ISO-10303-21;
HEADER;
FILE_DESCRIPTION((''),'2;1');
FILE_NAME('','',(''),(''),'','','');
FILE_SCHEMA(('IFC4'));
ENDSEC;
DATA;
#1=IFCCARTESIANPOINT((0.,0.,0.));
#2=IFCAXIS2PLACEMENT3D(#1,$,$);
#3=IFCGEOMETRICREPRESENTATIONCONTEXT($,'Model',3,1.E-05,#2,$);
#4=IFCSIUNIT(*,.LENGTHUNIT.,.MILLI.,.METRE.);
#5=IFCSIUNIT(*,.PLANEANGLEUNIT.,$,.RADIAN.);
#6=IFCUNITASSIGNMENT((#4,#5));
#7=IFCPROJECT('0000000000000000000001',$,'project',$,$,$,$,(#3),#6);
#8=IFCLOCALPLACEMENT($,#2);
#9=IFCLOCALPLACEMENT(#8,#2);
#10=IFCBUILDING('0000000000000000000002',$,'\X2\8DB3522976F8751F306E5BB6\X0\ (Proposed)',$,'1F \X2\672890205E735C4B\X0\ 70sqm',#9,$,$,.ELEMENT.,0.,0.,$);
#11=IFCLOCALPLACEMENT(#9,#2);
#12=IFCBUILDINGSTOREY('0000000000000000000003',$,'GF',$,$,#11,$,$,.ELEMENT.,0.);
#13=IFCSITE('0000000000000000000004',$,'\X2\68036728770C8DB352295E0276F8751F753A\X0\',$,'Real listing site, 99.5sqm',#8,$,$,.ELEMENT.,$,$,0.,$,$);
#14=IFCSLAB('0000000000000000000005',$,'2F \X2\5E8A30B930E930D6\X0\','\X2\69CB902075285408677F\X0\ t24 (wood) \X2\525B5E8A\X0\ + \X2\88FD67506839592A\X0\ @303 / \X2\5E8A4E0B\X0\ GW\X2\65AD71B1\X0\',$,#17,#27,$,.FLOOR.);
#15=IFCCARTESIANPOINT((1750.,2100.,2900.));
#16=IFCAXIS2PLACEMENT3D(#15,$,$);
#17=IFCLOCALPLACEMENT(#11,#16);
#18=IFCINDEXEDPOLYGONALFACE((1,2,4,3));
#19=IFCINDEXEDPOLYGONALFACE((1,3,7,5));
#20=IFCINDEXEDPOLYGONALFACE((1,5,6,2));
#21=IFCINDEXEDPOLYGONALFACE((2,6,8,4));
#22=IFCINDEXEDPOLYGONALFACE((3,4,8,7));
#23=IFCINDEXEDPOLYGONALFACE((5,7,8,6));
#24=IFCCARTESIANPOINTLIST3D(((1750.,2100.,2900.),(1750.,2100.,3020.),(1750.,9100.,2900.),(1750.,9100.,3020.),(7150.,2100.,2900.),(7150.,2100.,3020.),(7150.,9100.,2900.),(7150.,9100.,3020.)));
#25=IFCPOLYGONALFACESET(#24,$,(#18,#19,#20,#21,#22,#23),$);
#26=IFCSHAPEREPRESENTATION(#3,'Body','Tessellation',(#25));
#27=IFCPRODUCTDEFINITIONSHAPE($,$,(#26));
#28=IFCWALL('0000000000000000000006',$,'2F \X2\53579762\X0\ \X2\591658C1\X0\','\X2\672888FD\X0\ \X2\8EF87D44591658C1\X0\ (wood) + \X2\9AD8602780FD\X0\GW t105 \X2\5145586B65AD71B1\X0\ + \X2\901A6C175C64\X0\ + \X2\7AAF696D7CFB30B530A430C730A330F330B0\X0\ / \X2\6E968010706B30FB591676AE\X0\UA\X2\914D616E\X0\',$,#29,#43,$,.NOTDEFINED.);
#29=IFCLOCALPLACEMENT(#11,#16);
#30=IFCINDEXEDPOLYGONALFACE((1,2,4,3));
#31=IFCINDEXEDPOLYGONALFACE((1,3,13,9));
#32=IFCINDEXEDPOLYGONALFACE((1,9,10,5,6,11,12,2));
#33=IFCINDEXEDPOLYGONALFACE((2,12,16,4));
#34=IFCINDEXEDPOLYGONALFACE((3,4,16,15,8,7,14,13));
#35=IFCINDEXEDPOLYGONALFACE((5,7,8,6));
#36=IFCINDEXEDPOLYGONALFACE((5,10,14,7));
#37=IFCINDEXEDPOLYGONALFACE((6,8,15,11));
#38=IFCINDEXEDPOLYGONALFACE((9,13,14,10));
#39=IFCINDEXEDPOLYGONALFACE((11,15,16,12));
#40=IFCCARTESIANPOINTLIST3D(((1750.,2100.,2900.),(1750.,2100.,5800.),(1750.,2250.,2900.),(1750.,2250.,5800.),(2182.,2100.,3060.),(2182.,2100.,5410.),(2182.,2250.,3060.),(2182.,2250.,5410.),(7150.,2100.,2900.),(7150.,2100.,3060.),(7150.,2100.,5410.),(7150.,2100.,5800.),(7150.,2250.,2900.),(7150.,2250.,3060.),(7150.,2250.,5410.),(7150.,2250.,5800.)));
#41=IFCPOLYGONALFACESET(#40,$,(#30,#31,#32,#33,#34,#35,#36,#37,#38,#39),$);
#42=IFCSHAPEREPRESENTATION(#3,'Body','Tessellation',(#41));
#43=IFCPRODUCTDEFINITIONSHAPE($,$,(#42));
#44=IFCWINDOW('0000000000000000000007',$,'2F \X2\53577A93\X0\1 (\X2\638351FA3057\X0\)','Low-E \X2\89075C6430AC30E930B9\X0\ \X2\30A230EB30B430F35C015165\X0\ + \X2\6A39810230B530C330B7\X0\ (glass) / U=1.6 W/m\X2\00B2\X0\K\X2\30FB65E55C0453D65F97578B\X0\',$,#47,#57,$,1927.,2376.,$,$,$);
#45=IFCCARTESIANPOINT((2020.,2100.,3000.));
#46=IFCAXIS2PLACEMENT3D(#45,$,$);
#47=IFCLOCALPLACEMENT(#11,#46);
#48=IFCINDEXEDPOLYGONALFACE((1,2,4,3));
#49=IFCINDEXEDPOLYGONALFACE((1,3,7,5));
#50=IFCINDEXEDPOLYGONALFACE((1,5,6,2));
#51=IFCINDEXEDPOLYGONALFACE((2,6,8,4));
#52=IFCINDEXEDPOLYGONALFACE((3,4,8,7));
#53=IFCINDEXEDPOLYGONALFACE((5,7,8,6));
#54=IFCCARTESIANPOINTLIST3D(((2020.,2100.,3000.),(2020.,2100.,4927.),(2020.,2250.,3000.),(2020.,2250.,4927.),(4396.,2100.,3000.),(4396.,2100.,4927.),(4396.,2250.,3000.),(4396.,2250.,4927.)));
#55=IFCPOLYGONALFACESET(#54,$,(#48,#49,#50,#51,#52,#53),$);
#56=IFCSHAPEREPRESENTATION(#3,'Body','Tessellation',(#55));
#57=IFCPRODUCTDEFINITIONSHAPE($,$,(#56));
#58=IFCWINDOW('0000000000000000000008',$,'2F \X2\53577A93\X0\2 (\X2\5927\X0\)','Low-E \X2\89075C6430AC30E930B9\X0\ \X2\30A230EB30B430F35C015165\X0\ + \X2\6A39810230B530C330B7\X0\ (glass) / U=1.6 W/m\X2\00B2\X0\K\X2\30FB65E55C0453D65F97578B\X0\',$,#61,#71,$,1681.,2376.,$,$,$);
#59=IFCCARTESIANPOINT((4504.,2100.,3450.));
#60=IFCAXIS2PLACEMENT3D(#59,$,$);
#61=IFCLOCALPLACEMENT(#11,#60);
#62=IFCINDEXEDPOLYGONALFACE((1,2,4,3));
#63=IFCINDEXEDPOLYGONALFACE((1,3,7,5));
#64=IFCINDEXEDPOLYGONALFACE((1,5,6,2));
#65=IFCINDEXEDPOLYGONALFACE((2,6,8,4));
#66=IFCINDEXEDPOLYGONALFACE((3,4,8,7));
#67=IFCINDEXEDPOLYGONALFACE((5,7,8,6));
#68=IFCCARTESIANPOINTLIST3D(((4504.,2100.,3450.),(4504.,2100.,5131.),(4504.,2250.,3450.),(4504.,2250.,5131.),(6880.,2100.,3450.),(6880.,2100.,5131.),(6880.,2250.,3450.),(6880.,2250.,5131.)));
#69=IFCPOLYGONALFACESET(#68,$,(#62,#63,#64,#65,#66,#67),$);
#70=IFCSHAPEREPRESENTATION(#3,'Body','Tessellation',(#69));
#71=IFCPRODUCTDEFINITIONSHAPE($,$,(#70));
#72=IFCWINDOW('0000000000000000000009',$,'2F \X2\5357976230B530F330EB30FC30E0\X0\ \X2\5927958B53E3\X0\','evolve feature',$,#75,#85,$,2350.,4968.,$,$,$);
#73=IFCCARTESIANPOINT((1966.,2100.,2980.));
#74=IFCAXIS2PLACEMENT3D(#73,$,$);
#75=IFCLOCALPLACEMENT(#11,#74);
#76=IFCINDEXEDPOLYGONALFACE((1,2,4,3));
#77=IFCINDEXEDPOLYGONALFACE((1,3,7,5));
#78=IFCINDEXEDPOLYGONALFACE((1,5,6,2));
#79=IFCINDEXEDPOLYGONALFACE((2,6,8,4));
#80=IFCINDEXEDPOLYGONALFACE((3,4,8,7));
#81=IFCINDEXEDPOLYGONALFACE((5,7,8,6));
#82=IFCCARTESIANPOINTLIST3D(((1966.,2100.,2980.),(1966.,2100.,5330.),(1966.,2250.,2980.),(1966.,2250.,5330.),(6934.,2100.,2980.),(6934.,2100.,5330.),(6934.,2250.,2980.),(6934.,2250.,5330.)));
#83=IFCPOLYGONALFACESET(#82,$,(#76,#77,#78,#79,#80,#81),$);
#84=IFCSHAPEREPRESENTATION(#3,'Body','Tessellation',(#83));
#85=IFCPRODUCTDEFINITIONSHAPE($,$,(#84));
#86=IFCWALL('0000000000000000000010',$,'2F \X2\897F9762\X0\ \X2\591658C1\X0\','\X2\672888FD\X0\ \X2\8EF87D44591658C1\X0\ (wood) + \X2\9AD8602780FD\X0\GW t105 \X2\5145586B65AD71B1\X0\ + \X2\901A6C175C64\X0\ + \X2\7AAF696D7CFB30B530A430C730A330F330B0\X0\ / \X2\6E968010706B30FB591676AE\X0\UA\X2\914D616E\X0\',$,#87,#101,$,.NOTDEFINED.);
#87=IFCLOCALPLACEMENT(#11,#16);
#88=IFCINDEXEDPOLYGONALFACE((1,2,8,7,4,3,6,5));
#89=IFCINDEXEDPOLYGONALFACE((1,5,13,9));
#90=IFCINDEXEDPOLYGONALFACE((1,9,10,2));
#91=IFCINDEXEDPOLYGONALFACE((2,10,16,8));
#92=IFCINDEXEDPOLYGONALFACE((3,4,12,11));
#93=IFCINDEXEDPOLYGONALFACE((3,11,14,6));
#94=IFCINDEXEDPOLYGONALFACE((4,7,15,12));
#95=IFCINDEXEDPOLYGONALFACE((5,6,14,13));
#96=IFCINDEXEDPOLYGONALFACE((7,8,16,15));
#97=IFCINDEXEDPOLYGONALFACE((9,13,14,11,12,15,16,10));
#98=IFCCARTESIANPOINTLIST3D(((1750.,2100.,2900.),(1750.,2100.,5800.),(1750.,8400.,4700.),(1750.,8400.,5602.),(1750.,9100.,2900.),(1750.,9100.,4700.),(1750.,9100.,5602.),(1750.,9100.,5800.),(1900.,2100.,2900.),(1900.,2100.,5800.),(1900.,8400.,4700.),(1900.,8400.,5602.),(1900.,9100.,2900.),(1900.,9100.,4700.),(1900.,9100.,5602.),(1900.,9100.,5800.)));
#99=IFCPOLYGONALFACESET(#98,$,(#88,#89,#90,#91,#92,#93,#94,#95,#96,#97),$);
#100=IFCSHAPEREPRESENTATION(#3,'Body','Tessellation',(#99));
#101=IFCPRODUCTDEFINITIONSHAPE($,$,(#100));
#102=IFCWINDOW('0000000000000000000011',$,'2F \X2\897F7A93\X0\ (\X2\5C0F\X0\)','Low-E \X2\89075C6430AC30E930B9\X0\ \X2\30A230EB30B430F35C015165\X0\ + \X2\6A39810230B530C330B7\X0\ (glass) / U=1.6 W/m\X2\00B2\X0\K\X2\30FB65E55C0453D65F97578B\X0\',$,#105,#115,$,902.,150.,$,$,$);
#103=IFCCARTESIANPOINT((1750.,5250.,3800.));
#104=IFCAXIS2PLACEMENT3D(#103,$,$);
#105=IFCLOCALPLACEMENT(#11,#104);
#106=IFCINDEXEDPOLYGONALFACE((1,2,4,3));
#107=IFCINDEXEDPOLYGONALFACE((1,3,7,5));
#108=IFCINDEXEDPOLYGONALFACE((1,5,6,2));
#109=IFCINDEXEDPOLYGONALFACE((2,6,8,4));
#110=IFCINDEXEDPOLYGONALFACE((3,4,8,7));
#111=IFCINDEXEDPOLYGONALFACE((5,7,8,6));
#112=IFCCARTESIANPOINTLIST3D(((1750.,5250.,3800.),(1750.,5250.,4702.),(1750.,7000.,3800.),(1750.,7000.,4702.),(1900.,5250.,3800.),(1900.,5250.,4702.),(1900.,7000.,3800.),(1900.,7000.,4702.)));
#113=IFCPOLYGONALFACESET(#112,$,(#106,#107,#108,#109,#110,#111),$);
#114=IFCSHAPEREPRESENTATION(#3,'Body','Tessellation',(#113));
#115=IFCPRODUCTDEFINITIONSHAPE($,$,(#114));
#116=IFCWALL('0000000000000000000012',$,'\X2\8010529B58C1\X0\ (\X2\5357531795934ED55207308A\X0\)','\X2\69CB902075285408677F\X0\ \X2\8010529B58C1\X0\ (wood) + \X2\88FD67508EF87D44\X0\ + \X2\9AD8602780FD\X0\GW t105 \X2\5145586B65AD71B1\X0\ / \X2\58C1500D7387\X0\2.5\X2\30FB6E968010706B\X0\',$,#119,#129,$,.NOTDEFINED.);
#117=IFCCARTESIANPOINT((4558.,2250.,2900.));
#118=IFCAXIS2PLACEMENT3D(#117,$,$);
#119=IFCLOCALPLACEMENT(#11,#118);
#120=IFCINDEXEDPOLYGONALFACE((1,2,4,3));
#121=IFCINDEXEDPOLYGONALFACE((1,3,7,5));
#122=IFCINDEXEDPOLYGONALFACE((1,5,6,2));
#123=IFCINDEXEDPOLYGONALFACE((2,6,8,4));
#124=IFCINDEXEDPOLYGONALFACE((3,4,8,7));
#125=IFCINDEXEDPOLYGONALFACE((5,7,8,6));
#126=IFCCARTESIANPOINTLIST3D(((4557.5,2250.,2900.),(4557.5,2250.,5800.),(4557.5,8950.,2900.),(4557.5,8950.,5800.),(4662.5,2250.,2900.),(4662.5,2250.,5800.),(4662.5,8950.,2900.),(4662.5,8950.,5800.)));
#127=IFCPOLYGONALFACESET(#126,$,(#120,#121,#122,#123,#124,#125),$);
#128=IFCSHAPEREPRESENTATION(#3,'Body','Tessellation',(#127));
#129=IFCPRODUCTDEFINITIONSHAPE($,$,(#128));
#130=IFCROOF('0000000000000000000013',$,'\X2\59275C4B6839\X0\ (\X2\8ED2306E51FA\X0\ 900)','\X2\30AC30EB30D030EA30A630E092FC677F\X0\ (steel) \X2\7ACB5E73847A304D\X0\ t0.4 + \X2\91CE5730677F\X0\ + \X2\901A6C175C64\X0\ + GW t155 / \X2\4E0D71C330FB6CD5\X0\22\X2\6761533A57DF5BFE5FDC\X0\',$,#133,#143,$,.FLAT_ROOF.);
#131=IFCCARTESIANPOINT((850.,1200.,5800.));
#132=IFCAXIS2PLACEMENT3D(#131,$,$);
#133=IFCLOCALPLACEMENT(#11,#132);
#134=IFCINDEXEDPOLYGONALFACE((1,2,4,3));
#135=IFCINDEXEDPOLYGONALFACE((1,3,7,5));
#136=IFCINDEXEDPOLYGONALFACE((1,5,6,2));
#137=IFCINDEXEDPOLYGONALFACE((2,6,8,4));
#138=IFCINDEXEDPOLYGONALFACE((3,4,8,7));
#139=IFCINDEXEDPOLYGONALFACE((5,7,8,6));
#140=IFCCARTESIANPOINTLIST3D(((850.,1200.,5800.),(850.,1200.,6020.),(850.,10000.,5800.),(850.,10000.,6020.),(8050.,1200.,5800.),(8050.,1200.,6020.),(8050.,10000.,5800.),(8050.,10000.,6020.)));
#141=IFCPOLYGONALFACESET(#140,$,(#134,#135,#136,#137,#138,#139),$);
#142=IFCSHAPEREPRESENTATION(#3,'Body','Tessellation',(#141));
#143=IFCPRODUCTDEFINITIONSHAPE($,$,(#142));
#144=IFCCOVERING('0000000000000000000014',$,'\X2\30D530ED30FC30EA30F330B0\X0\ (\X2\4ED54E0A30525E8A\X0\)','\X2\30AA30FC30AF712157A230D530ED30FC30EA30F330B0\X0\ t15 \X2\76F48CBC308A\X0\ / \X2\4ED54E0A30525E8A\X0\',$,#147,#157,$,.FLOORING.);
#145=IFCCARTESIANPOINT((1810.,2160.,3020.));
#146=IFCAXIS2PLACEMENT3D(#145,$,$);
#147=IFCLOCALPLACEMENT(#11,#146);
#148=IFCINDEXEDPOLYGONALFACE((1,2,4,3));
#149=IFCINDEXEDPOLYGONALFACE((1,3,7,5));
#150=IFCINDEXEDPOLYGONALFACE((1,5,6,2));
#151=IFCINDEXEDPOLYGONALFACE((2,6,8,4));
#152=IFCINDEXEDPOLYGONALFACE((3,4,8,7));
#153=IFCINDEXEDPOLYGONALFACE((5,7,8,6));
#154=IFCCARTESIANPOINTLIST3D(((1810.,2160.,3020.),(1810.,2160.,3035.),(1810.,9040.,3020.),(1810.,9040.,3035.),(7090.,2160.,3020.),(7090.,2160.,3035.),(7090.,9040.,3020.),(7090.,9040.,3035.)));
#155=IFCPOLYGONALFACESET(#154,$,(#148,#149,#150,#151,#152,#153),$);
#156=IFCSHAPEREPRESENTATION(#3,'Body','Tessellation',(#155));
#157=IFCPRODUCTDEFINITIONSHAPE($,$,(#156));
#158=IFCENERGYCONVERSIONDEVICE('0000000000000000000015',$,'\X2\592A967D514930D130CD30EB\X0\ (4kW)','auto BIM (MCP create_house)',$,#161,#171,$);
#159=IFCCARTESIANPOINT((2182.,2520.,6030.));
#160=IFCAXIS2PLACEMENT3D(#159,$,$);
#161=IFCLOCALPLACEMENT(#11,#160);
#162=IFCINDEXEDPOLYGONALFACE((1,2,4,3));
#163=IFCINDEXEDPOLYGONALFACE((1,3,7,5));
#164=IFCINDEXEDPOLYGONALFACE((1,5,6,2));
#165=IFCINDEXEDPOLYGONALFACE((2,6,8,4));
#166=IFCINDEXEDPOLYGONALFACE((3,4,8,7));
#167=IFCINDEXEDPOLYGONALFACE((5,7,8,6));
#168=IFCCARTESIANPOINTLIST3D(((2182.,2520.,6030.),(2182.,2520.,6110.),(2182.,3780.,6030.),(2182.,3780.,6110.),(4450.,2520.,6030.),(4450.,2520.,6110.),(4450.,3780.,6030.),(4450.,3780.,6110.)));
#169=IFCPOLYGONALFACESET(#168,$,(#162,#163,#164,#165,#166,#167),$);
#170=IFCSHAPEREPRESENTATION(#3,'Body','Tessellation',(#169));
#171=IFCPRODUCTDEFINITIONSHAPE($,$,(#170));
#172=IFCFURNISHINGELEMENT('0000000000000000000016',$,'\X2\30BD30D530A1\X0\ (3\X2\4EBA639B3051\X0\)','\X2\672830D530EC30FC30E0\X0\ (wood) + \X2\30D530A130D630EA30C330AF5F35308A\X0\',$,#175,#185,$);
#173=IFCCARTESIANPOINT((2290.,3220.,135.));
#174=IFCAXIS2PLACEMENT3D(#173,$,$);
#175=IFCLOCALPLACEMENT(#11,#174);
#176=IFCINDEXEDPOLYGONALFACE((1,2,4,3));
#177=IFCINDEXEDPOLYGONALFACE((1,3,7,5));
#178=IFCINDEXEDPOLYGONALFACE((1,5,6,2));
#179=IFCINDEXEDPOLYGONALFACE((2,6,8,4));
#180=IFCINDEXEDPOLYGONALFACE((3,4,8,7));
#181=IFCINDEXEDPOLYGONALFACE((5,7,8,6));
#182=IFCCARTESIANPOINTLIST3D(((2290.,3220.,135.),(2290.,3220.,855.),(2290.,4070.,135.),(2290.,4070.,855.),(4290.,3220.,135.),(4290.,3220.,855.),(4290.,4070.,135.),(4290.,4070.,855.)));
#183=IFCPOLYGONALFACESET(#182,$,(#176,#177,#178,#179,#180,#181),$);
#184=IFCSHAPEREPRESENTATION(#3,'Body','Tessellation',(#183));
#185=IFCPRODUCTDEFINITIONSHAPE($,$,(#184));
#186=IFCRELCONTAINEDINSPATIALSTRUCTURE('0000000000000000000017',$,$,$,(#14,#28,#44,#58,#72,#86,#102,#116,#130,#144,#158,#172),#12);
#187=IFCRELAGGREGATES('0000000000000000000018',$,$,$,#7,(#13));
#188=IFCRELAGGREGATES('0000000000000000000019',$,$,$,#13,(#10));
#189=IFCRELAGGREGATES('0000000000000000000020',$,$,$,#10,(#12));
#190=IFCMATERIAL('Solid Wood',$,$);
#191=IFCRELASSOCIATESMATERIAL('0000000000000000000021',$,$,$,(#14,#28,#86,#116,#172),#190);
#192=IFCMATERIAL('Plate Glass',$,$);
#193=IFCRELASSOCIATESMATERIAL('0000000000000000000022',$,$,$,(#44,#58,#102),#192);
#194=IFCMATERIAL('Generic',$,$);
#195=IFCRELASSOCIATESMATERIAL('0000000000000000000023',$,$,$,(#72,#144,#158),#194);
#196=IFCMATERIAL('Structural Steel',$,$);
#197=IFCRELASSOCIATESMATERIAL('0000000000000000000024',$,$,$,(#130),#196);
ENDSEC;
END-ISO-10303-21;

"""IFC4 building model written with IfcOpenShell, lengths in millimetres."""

from ifc_helpers import new_model, si_unit, frame, frame_2d, origin, place, context, project, spatial, rectangle, extrude, material, element, fill, save


model = new_model("IFC4")

# Units and contexts
model_context = context("Model", 3, precision=1e-05, world=origin())
ifc_project = project(units=[si_unit("LENGTHUNIT", "METRE", prefix="MILLI"), si_unit("PLANEANGLEUNIT", "RADIAN")], contexts=[model_context])

# Site, building, storey
site_placement = place(None, origin())
site = spatial("IfcSite", under=ifc_project, at=site_placement, Name="栃木県足利市相生町", ObjectType="Real listing site, 99.5sqm", CompositionType="ELEMENT", RefElevation=0.0)
building_placement = place(site_placement, origin())
building = spatial("IfcBuilding", under=site, at=building_placement, Name="足利相生の家 (Proposed)", ObjectType="1F 木造平屋 70sqm", CompositionType="ELEMENT", ElevationOfRefHeight=0.0, ElevationOfTerrain=0.0)
storey_placement = place(building_placement, origin())
storey = spatial("IfcBuildingStorey", under=building, at=storey_placement, Name="GF", CompositionType="ELEMENT", Elevation=0.0)

# Slab
ifc_material_1 = material(Name="Solid Wood")
slab_placement = place(storey_placement, frame((1750.0, 2100.0, 2900.0)))
element("IfcSlab", 1, at=slab_placement, inside=storey, material=ifc_material_1, Name="2F 床スラブ", Description="構造用合板 t24 (wood) 剛床 + 製材根太 @303 / 床下 GW断熱", PredefinedType="FLOOR", context=model_context, shape_type="SweptSolid", body=[
    extrude(rectangle(XDim=5400.0, YDim=7000.0, at=frame_2d((2700.0, 3500.0))), frame((1750.0, 2100.0, 2900.0)), (0.0, 0.0, 1.0), 120.0),
])

# Wall, openings, windows
wall_1_placement = place(storey_placement, frame((1750.0, 2100.0, 2900.0)))
wall_1 = element("IfcWall", 2, at=wall_1_placement, inside=storey, material=ifc_material_1, Name="2F 南面 外壁", Description="木製 軸組外壁 (wood) + 高性能GW t105 充填断熱 + 通気層 + 窯業系サイディング / 準耐火・外皮UA配慮", PredefinedType="NOTDEFINED", context=model_context, shape_type="SweptSolid", body=[
    extrude(rectangle(XDim=5400.0, YDim=150.0, at=frame_2d((2700.0, 75.0))), frame((1750.0, 2100.0, 2900.0)), (0.0, 0.0, 1.0), 2900.0),
])
opening_1_placement = place(storey_placement, frame((2020.0, 2100.0, 3000.0)))
opening_1 = element("IfcOpeningElement", 3, at=opening_1_placement, cuts=wall_1, PredefinedType="NOTDEFINED", context=model_context, shape_type="SweptSolid", body=[
    extrude(rectangle(XDim=2376.0, YDim=150.0, at=frame_2d((1188.0, 75.0))), frame((2020.0, 2100.0, 3000.0)), (0.0, 0.0, 1.0), 1927.0),
])
opening_2_placement = place(storey_placement, frame((4504.0, 2100.0, 3450.0)))
opening_2 = element("IfcOpeningElement", 4, at=opening_2_placement, cuts=wall_1, PredefinedType="NOTDEFINED", context=model_context, shape_type="SweptSolid", body=[
    extrude(rectangle(XDim=2376.0, YDim=150.0, at=frame_2d((1188.0, 75.0))), frame((4504.0, 2100.0, 3450.0)), (0.0, 0.0, 1.0), 1681.0),
])
opening_3_placement = place(storey_placement, frame((1966.0, 2100.0, 2980.0)))
opening_3 = element("IfcOpeningElement", 5, at=opening_3_placement, cuts=wall_1, PredefinedType="NOTDEFINED", context=model_context, shape_type="SweptSolid", body=[
    extrude(rectangle(XDim=4968.0, YDim=150.0, at=frame_2d((2484.0, 75.0))), frame((1966.0, 2100.0, 2980.0)), (0.0, 0.0, 1.0), 2350.0),
])
ifc_material_2 = material(Name="Plate Glass")
window_1_placement = place(storey_placement, frame((2020.0, 2100.0, 3000.0)))
window_1 = element("IfcWindow", 6, at=window_1_placement, inside=storey, material=ifc_material_2, Name="2F 南窓1 (掃出し)", Description="Low-E 複層ガラス アルゴン封入 + 樹脂サッシ (glass) / U=1.6 W/m²K・日射取得型", OverallHeight=1927.0, OverallWidth=2376.0, context=model_context, shape_type="SweptSolid", body=[
    extrude(rectangle(XDim=2376.0, YDim=150.0, at=frame_2d((1188.0, 75.0))), frame((2020.0, 2100.0, 3000.0)), (0.0, 0.0, 1.0), 1927.0),
])
fill(opening_1, window_1)
window_2_placement = place(storey_placement, frame((4504.0, 2100.0, 3450.0)))
window_2 = element("IfcWindow", 7, at=window_2_placement, inside=storey, material=ifc_material_2, Name="2F 南窓2 (大)", Description="Low-E 複層ガラス アルゴン封入 + 樹脂サッシ (glass) / U=1.6 W/m²K・日射取得型", OverallHeight=1681.0, OverallWidth=2376.0, context=model_context, shape_type="SweptSolid", body=[
    extrude(rectangle(XDim=2376.0, YDim=150.0, at=frame_2d((1188.0, 75.0))), frame((4504.0, 2100.0, 3450.0)), (0.0, 0.0, 1.0), 1681.0),
])
fill(opening_2, window_2)
ifc_material_3 = material(Name="Generic")
window_3_placement = place(storey_placement, frame((1966.0, 2100.0, 2980.0)))
window_3 = element("IfcWindow", 8, at=window_3_placement, inside=storey, material=ifc_material_3, Name="2F 南面サンルーム 大開口", Description="evolve feature", OverallHeight=2350.0, OverallWidth=4968.0, context=model_context, shape_type="SweptSolid", body=[
    extrude(rectangle(XDim=4968.0, YDim=150.0, at=frame_2d((2484.0, 75.0))), frame((1966.0, 2100.0, 2980.0)), (0.0, 0.0, 1.0), 2350.0),
])
fill(opening_3, window_3)

# Wall, opening, window
wall_2_placement = place(storey_placement, frame((1750.0, 2100.0, 2900.0)))
wall_2 = element("IfcWall", 9, at=wall_2_placement, inside=storey, material=ifc_material_1, Name="2F 西面 外壁", Description="木製 軸組外壁 (wood) + 高性能GW t105 充填断熱 + 通気層 + 窯業系サイディング / 準耐火・外皮UA配慮", PredefinedType="NOTDEFINED", context=model_context, shape_type="SweptSolid", body=[
    extrude(rectangle(XDim=150.0, YDim=7000.0, at=frame_2d((75.0, 3500.0))), frame((1750.0, 2100.0, 2900.0)), (0.0, 0.0, 1.0), 2900.0),
])
opening_4_placement = place(storey_placement, frame((1750.0, 5250.0, 3800.0)))
opening_4 = element("IfcOpeningElement", 10, at=opening_4_placement, cuts=wall_2, PredefinedType="NOTDEFINED", context=model_context, shape_type="SweptSolid", body=[
    extrude(rectangle(XDim=150.0, YDim=1750.0, at=frame_2d((75.0, 875.0))), frame((1750.0, 5250.0, 3800.0)), (0.0, 0.0, 1.0), 902.0),
])
window_4_placement = place(storey_placement, frame((1750.0, 5250.0, 3800.0)))
window_4 = element("IfcWindow", 11, at=window_4_placement, inside=storey, material=ifc_material_2, Name="2F 西窓 (小)", Description="Low-E 複層ガラス アルゴン封入 + 樹脂サッシ (glass) / U=1.6 W/m²K・日射取得型", OverallHeight=902.0, OverallWidth=150.0, context=model_context, shape_type="SweptSolid", body=[
    extrude(rectangle(XDim=150.0, YDim=1750.0, at=frame_2d((75.0, 875.0))), frame((1750.0, 5250.0, 3800.0)), (0.0, 0.0, 1.0), 902.0),
])
fill(opening_4, window_4)

# Wall
wall_3_placement = place(storey_placement, frame((4558.0, 2250.0, 2900.0)))
element("IfcWall", 12, at=wall_3_placement, inside=storey, material=ifc_material_1, Name="耐力壁 (南北間仕切り)", Description="構造用合板 耐力壁 (wood) + 製材軸組 + 高性能GW t105 充填断熱 / 壁倍率2.5・準耐火", PredefinedType="NOTDEFINED", context=model_context, shape_type="SweptSolid", body=[
    extrude(rectangle(XDim=105.0, YDim=6700.0, at=frame_2d((52.0, 3350.0))), frame((4558.0, 2250.0, 2900.0)), (0.0, 0.0, 1.0), 2900.0),
])

# Roof
ifc_material_4 = material(Name="Structural Steel")
roof_placement = place(storey_placement, frame((850.0, 1200.0, 5800.0)))
element("IfcRoof", 13, at=roof_placement, inside=storey, material=ifc_material_4, Name="大屋根 (軒の出 900)", Description="ガルバリウム鋼板 (steel) 立平葺き t0.4 + 野地板 + 通気層 + GW t155 / 不燃・法22条区域対応", PredefinedType="FLAT_ROOF", context=model_context, shape_type="SweptSolid", body=[
    extrude(rectangle(XDim=7200.0, YDim=8800.0, at=frame_2d((3600.0, 4400.0))), frame((850.0, 1200.0, 5800.0)), (0.0, 0.0, 1.0), 220.0),
])

# Covering
covering_placement = place(storey_placement, frame((1810.0, 2160.0, 3020.0)))
element("IfcCovering", 14, at=covering_placement, inside=storey, material=ifc_material_3, Name="フローリング (仕上げ床)", Description="オーク無垢フローリング t15 直貼り / 仕上げ床", PredefinedType="FLOORING", context=model_context, shape_type="SweptSolid", body=[
    extrude(rectangle(XDim=5280.0, YDim=6880.0, at=frame_2d((2640.0, 3440.0))), frame((1810.0, 2160.0, 3020.0)), (0.0, 0.0, 1.0), 15.0),
])

# Energy conversion device
energy_conversion_device_placement = place(storey_placement, frame((2182.0, 2520.0, 6030.0)))
element("IfcEnergyConversionDevice", 15, at=energy_conversion_device_placement, inside=storey, material=ifc_material_3, Name="太陽光パネル (4kW)", Description="auto BIM (MCP create_house)", context=model_context, shape_type="SweptSolid", body=[
    extrude(rectangle(XDim=2268.0, YDim=1260.0, at=frame_2d((1134.0, 630.0))), frame((2182.0, 2520.0, 6030.0)), (0.0, 0.0, 1.0), 80.0),
])

# Furnishing element
furnishing_1_placement = place(storey_placement, frame((2290.0, 3220.0, 135.0)))
element("IfcFurnishingElement", 16, at=furnishing_1_placement, inside=storey, material=ifc_material_1, Name="ソファ (3人掛け)", Description="木フレーム (wood) + ファブリック張り", context=model_context, shape_type="SweptSolid", body=[
    extrude(rectangle(XDim=2000.0, YDim=850.0, at=frame_2d((1000.0, 425.0))), frame((2290.0, 3220.0, 135.0)), (0.0, 0.0, 1.0), 720.0),
])

save(model, "model.ifc")
